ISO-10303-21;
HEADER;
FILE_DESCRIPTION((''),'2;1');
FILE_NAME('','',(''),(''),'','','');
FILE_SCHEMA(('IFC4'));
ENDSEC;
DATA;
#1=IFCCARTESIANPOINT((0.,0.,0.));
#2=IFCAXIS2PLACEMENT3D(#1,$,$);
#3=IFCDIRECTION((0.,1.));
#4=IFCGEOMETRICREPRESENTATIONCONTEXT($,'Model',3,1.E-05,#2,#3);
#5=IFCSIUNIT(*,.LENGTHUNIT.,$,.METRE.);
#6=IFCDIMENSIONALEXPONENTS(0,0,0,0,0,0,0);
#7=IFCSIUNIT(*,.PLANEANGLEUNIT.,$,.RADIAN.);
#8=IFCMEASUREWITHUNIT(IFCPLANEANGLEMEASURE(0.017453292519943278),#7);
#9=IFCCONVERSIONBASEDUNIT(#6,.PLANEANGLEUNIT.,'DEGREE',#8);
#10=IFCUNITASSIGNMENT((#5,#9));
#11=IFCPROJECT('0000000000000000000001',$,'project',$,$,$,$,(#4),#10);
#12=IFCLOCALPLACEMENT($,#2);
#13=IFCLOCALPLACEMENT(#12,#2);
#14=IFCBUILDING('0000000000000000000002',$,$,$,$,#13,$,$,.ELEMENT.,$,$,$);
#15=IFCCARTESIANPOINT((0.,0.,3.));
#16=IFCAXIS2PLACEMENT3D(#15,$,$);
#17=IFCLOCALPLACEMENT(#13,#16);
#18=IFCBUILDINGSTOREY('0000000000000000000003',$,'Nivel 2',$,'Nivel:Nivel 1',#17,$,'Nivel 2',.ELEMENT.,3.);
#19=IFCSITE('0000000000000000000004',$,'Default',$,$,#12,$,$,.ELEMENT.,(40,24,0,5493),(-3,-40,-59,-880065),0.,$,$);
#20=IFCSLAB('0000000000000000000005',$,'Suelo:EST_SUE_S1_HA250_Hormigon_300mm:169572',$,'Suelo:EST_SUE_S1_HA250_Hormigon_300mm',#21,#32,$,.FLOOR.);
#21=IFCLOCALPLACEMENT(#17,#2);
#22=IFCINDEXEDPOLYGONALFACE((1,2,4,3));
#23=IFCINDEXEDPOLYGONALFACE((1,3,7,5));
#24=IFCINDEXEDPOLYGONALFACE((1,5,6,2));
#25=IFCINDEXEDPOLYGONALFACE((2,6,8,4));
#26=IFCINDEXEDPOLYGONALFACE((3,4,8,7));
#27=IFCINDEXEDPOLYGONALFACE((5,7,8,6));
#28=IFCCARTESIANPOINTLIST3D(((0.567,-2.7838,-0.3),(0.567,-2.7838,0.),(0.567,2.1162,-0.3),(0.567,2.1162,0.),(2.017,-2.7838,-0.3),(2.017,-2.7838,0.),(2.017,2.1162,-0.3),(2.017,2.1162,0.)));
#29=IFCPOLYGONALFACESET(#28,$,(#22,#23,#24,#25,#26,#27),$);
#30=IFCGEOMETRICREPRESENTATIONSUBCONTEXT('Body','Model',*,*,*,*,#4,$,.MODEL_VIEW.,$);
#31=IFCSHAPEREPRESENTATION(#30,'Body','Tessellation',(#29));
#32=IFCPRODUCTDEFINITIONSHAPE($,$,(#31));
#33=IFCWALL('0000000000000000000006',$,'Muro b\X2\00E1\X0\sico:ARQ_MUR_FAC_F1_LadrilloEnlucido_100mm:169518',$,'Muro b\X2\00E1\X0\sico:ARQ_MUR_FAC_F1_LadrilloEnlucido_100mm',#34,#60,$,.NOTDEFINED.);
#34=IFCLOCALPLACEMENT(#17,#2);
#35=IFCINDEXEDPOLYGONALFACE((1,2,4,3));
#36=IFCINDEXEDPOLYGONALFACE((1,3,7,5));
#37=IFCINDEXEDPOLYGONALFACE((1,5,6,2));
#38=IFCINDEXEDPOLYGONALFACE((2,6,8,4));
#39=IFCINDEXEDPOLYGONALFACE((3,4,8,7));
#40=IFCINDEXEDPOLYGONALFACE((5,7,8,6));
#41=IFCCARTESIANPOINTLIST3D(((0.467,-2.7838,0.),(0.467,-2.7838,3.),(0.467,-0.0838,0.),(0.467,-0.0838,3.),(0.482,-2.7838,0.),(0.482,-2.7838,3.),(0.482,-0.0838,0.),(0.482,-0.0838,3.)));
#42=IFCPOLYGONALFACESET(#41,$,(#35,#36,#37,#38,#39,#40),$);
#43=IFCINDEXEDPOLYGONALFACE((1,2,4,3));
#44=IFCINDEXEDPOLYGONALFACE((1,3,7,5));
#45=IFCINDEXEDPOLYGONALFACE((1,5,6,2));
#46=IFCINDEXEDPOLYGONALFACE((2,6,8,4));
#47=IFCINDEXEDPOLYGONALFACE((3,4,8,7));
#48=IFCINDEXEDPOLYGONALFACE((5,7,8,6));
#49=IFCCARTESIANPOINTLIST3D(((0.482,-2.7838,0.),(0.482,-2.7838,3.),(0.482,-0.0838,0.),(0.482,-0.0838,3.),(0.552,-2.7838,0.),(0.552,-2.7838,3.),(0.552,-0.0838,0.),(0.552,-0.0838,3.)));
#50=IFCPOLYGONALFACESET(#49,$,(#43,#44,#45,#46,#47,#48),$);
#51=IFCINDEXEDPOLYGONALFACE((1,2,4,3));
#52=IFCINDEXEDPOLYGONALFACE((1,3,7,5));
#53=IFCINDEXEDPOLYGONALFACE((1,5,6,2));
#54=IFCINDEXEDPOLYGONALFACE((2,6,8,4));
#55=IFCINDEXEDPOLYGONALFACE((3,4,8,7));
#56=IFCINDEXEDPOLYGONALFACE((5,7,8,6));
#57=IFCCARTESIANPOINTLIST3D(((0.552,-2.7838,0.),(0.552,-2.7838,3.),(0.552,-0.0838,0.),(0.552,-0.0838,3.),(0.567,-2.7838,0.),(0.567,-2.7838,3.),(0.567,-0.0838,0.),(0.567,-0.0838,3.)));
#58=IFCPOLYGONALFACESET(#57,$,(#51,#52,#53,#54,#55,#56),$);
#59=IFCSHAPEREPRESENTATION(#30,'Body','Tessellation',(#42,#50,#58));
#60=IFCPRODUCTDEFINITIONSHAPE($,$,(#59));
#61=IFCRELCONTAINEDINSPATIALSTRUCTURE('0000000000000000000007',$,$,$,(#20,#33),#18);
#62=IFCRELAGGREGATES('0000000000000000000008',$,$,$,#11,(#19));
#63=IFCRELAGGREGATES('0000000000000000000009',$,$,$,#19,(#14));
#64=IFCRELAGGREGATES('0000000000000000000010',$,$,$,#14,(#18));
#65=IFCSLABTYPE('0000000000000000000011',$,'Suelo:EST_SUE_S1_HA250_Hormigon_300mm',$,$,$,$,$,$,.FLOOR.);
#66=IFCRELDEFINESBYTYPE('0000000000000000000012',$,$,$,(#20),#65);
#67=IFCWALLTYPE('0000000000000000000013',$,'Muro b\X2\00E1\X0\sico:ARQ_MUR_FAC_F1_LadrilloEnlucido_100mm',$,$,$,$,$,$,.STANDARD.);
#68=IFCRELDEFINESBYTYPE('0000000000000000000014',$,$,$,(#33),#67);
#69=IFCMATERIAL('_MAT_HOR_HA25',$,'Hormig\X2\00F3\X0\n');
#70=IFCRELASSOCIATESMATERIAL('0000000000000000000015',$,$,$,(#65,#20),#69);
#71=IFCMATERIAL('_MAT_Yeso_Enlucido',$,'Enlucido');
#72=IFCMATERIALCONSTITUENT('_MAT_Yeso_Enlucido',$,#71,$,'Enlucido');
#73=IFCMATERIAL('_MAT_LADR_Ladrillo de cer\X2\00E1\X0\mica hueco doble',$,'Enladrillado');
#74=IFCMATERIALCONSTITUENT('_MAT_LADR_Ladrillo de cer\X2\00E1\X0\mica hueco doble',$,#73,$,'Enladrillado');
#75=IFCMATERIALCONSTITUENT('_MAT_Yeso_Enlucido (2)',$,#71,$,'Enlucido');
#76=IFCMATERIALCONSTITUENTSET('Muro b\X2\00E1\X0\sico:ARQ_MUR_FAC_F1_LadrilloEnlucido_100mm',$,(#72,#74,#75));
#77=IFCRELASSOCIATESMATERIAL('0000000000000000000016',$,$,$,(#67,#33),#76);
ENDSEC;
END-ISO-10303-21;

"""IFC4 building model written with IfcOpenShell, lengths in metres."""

from ifc_helpers import new_model, entity, si_unit, converted_unit, direction, frame, origin, place, context, subcontext, project, spatial, indexed_curve, outline, extrude, material, constituent, constituent_set, type_object, element, save


model = new_model("IFC4")

# Units and contexts
model_context = context("Model", 3, precision=1e-05, world=origin(), true_north=direction((0.0, 1.0)))
body_context = subcontext(model_context, "Body", "Model", "MODEL_VIEW")
ifc_project = project(units=[si_unit("LENGTHUNIT", "METRE"), converted_unit("PLANEANGLEUNIT", "DEGREE", entity("IfcPlaneAngleMeasure", 0.017453292519943278), si_unit("PLANEANGLEUNIT", "RADIAN"), dimensions=[0, 0, 0, 0, 0, 0, 0])], contexts=[model_context])

# Site, building, storey
site_placement = place(None, origin())
site = spatial("IfcSite", under=ifc_project, at=site_placement, Name="Default", CompositionType="ELEMENT", RefLatitude=(40, 24, 0, 5493), RefLongitude=(-3, -40, -59, -880065), RefElevation=0.0)
building_placement = place(site_placement, origin())
building = spatial("IfcBuilding", under=site, at=building_placement, CompositionType="ELEMENT")
storey_placement = place(building_placement, frame((0.0, 0.0, 3.0)))
storey = spatial("IfcBuildingStorey", under=building, at=storey_placement, Name="Nivel 2", ObjectType="Nivel:Nivel 1", LongName="Nivel 2", CompositionType="ELEMENT", Elevation=3.0)

# Slab
ifc_material_1 = material(Name="_MAT_HOR_HA25", Category="Hormigón")
slab_type = type_object("IfcSlabType", Name="Suelo:EST_SUE_S1_HA250_Hormigon_300mm", PredefinedType="FLOOR", material=ifc_material_1)
slab_placement = place(storey_placement, origin())
element("IfcSlab", 1, at=slab_placement, inside=storey, type_object=slab_type, material=ifc_material_1, Name="Suelo:EST_SUE_S1_HA250_Hormigon_300mm:169572", ObjectType="Suelo:EST_SUE_S1_HA250_Hormigon_300mm", PredefinedType="FLOOR", context=body_context, shape_type="SweptSolid", body=[
    extrude(outline(indexed_curve([(-2.45, -0.725), (2.45, -0.725), (2.45, 0.725), (-2.45, 0.725), (-2.45, -0.725)], self_intersect=False)), frame((1.292, -0.3338, 0.0), z_axis=(0.0, 0.0, -1.0), x_axis=(0.0, 1.0, 0.0)), (0.0, 0.0, 1.0), 0.3),
])

# Wall
ifc_material_2 = material(Name="_MAT_Yeso_Enlucido", Category="Enlucido")
ifc_constituent_1 = constituent(ifc_material_2, Name="_MAT_Yeso_Enlucido", Category="Enlucido")
ifc_material_3 = material(Name="_MAT_LADR_Ladrillo de cerámica hueco doble", Category="Enladrillado")
ifc_constituent_2 = constituent(ifc_material_3, Name="_MAT_LADR_Ladrillo de cerámica hueco doble", Category="Enladrillado")
ifc_constituent_3 = constituent(ifc_material_2, Name="_MAT_Yeso_Enlucido (2)", Category="Enlucido")
ifc_constituent_set = constituent_set(constituents=[ifc_constituent_1, ifc_constituent_2, ifc_constituent_3], Name="Muro básico:ARQ_MUR_FAC_F1_LadrilloEnlucido_100mm")
wall_type = type_object("IfcWallType", Name="Muro básico:ARQ_MUR_FAC_F1_LadrilloEnlucido_100mm", PredefinedType="STANDARD", material=ifc_constituent_set)
wall_placement = place(storey_placement, frame((0.517, -2.7838, 0.0), z_axis=(0.0, 0.0, 1.0), x_axis=(0.0, 1.0, 0.0)))
element("IfcWall", 2, at=wall_placement, inside=storey, type_object=wall_type, material=ifc_constituent_set, Name="Muro básico:ARQ_MUR_FAC_F1_LadrilloEnlucido_100mm:169518", ObjectType="Muro básico:ARQ_MUR_FAC_F1_LadrilloEnlucido_100mm", PredefinedType="NOTDEFINED", context=body_context, shape_type="SweptSolid", body=[
    extrude(outline(indexed_curve([(-0.0075, -1.35), (0.0075, -1.35), (0.0075, 1.35), (-0.0075, 1.35), (-0.0075, -1.35)], self_intersect=False)), frame((1.35, 0.0425, 0.0), z_axis=(0.0, 0.0, 1.0), x_axis=(0.0, -1.0, 0.0)), (0.0, 0.0, 1.0), 3.0),
    extrude(outline(indexed_curve([(-1.35, -0.035), (1.35, -0.035), (1.35, 0.035), (-1.35, 0.035), (-1.35, -0.035)], self_intersect=False)), frame((1.35, 0.0, 0.0)), (0.0, 0.0, 1.0), 3.0),
    extrude(outline(indexed_curve([(-0.0075, -1.35), (0.0075, -1.35), (0.0075, 1.35), (-0.0075, 1.35), (-0.0075, -1.35)], self_intersect=False)), frame((1.35, -0.0425, 0.0), z_axis=(0.0, 0.0, 1.0), x_axis=(0.0, 1.0, 0.0)), (0.0, 0.0, 1.0), 3.0),
])

save(model, "model.ifc")
